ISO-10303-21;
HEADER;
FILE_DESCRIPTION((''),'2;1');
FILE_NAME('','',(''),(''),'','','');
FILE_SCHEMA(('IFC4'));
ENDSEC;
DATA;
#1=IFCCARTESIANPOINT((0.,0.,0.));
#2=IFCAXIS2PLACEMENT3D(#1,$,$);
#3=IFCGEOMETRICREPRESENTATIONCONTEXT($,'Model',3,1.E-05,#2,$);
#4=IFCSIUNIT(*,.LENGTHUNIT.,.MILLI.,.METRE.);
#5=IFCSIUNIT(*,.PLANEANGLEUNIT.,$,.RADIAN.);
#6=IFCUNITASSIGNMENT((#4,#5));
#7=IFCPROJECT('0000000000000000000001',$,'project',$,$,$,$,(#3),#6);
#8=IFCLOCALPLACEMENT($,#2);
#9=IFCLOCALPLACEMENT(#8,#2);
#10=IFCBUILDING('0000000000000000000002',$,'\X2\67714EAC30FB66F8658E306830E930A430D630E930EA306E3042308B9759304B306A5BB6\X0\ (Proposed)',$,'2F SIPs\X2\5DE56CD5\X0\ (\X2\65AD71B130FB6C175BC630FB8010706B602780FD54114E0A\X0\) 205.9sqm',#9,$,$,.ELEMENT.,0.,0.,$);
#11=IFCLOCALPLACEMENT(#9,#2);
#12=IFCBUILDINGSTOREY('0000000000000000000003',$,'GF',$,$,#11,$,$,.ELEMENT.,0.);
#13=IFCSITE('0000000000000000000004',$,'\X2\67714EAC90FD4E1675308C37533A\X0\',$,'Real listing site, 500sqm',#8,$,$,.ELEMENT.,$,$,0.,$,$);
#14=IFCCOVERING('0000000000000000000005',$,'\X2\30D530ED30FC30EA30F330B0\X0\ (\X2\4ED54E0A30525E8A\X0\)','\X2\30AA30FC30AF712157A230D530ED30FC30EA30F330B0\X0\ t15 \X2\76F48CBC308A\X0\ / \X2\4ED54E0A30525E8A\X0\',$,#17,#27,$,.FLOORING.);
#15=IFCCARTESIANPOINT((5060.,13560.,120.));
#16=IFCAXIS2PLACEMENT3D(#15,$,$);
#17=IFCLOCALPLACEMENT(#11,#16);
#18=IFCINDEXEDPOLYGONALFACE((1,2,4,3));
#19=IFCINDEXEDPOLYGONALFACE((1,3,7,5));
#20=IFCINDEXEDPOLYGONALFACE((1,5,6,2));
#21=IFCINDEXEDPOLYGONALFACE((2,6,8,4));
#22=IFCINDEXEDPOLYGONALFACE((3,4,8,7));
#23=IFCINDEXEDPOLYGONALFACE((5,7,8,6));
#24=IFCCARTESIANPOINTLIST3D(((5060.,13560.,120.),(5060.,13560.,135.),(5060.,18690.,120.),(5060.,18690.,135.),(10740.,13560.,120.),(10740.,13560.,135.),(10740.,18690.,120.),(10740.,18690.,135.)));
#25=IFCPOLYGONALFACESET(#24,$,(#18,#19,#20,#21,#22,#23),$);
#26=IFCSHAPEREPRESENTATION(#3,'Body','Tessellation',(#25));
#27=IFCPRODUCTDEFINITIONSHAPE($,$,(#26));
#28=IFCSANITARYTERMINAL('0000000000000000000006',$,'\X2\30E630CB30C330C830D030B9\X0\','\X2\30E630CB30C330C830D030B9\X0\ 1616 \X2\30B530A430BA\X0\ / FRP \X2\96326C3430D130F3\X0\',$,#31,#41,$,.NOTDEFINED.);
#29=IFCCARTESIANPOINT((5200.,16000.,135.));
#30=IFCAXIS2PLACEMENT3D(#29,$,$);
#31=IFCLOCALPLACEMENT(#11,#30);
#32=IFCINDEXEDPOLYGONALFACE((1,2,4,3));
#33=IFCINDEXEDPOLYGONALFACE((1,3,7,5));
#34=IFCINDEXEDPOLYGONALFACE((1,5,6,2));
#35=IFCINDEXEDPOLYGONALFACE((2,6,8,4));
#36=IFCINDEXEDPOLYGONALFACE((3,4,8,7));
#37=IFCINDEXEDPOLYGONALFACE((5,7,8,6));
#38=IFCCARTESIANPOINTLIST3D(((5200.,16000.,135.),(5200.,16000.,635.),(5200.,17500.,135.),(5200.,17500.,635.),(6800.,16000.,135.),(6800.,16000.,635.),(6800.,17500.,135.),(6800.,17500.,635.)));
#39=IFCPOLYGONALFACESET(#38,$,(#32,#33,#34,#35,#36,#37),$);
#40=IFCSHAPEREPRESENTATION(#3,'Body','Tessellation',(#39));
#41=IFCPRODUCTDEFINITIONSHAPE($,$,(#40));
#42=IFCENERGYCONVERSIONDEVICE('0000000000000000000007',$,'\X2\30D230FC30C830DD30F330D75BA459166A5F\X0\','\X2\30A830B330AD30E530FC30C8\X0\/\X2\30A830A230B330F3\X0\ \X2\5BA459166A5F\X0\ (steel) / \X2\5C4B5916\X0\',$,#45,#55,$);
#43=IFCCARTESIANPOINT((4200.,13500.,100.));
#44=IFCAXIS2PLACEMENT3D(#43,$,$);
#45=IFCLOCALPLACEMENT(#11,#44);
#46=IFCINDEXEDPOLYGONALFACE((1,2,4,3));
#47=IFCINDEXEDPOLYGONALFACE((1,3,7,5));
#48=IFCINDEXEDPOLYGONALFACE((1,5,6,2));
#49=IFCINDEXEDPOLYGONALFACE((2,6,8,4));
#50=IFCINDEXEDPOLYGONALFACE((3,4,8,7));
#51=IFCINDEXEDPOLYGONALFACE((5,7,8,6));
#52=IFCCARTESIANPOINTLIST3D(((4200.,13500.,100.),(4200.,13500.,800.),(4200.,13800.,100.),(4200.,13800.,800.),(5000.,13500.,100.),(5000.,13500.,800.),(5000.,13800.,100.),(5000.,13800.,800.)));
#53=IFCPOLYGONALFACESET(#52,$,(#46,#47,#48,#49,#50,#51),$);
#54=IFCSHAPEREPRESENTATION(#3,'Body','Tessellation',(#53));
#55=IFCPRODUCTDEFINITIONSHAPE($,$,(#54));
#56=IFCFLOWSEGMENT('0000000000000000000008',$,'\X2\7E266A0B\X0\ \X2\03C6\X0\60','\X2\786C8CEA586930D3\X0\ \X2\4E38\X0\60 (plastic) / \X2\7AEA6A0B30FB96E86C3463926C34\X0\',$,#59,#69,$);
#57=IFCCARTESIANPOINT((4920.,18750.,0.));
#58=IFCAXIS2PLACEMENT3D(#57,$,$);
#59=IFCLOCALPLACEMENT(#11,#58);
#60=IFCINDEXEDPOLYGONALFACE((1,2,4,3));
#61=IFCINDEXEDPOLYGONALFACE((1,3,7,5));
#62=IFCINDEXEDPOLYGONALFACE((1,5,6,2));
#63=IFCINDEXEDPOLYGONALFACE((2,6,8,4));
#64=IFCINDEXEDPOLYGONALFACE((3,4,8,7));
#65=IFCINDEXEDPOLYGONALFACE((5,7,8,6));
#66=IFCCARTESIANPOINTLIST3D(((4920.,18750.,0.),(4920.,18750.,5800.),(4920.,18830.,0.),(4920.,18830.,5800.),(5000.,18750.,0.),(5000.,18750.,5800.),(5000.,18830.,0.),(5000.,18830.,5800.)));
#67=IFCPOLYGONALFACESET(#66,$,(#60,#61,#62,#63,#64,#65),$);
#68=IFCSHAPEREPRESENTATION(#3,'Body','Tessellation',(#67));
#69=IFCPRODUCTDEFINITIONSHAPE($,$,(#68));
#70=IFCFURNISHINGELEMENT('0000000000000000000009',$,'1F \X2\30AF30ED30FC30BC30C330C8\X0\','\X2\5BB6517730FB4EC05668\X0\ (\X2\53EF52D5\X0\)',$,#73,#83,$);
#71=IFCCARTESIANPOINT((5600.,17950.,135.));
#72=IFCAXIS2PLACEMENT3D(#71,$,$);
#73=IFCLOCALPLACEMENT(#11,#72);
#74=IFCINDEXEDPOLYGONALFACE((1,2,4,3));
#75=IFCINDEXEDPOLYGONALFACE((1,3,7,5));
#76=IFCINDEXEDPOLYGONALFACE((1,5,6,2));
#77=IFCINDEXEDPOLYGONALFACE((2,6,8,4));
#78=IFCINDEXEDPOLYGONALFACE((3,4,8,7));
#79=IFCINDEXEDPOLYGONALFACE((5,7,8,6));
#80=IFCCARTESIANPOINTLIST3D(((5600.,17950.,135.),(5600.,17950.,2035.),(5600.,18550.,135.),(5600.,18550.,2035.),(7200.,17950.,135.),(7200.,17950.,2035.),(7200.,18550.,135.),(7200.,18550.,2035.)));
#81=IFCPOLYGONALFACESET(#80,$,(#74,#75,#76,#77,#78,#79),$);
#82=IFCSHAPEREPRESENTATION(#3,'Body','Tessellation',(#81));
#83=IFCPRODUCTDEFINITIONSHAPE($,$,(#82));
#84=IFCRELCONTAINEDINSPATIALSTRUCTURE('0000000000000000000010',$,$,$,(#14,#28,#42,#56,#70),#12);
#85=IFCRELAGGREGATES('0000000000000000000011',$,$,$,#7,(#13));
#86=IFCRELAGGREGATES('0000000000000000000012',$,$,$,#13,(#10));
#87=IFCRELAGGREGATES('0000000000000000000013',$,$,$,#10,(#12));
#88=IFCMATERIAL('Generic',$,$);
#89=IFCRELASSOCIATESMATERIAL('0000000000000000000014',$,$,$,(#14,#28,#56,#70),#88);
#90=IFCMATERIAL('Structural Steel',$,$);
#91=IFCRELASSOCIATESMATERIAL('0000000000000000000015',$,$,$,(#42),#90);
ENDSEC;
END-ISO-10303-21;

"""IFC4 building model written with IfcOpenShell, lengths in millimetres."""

from ifc_helpers import new_model, si_unit, frame, frame_2d, origin, place, context, project, spatial, rectangle, extrude, material, element, save


model = new_model("IFC4")

# Units and contexts
model_context = context("Model", 3, precision=1e-05, world=origin())
ifc_project = project(units=[si_unit("LENGTHUNIT", "METRE", prefix="MILLI"), si_unit("PLANEANGLEUNIT", "RADIAN")], contexts=[model_context])

# Site, building, storey
site_placement = place(None, origin())
site = spatial("IfcSite", under=ifc_project, at=site_placement, Name="東京都世田谷区", ObjectType="Real listing site, 500sqm", CompositionType="ELEMENT", RefElevation=0.0)
building_placement = place(site_placement, origin())
building = spatial("IfcBuilding", under=site, at=building_placement, Name="東京・書斎とライブラリのある静かな家 (Proposed)", ObjectType="2F SIPs工法 (断熱・気密・耐火性能向上) 205.9sqm", CompositionType="ELEMENT", ElevationOfRefHeight=0.0, ElevationOfTerrain=0.0)
storey_placement = place(building_placement, origin())
storey = spatial("IfcBuildingStorey", under=building, at=storey_placement, Name="GF", CompositionType="ELEMENT", Elevation=0.0)

# Covering
ifc_material_1 = material(Name="Generic")
covering_placement = place(storey_placement, frame((5060.0, 13560.0, 120.0)))
element("IfcCovering", 1, at=covering_placement, inside=storey, material=ifc_material_1, Name="フローリング (仕上げ床)", Description="オーク無垢フローリング t15 直貼り / 仕上げ床", PredefinedType="FLOORING", context=model_context, shape_type="SweptSolid", body=[
    extrude(rectangle(XDim=5680.0, YDim=5130.0, at=frame_2d((2840.0, 2565.0))), frame((5060.0, 13560.0, 120.0)), (0.0, 0.0, 1.0), 15.0),
])

# Sanitary terminal
sanitary_terminal_placement = place(storey_placement, frame((5200.0, 16000.0, 135.0)))
element("IfcSanitaryTerminal", 2, at=sanitary_terminal_placement, inside=storey, material=ifc_material_1, Name="ユニットバス", Description="ユニットバス 1616 サイズ / FRP 防水パン", PredefinedType="NOTDEFINED", context=model_context, shape_type="SweptSolid", body=[
    extrude(rectangle(XDim=1600.0, YDim=1500.0, at=frame_2d((800.0, 750.0))), frame((5200.0, 16000.0, 135.0)), (0.0, 0.0, 1.0), 500.0),
])

# Energy conversion device
ifc_material_2 = material(Name="Structural Steel")
energy_conversion_device_placement = place(storey_placement, frame((4200.0, 13500.0, 100.0)))
element("IfcEnergyConversionDevice", 3, at=energy_conversion_device_placement, inside=storey, material=ifc_material_2, Name="ヒートポンプ室外機", Description="エコキュート/エアコン 室外機 (steel) / 屋外", context=model_context, shape_type="SweptSolid", body=[
    extrude(rectangle(XDim=800.0, YDim=300.0, at=frame_2d((400.0, 150.0))), frame((4200.0, 13500.0, 100.0)), (0.0, 0.0, 1.0), 700.0),
])

# Flow segment
flow_segment_placement = place(storey_placement, frame((4920.0, 18750.0, 0.0)))
element("IfcFlowSegment", 4, at=flow_segment_placement, inside=storey, material=ifc_material_1, Name="縦樋 φ60", Description="硬質塩ビ 丸60 (plastic) / 竪樋・雨水排水", context=model_context, shape_type="SweptSolid", body=[
    extrude(rectangle(XDim=80.0, YDim=80.0, at=frame_2d((40.0, 40.0))), frame((4920.0, 18750.0, 0.0)), (0.0, 0.0, 1.0), 5800.0),
])

# Furnishing element
furnishing_placement = place(storey_placement, frame((5600.0, 17950.0, 135.0)))
element("IfcFurnishingElement", 5, at=furnishing_placement, inside=storey, material=ifc_material_1, Name="1F クローゼット", Description="家具・什器 (可動)", context=model_context, shape_type="SweptSolid", body=[
    extrude(rectangle(XDim=1600.0, YDim=600.0, at=frame_2d((800.0, 300.0))), frame((5600.0, 17950.0, 135.0)), (0.0, 0.0, 1.0), 1900.0),
])

save(model, "model.ifc")
